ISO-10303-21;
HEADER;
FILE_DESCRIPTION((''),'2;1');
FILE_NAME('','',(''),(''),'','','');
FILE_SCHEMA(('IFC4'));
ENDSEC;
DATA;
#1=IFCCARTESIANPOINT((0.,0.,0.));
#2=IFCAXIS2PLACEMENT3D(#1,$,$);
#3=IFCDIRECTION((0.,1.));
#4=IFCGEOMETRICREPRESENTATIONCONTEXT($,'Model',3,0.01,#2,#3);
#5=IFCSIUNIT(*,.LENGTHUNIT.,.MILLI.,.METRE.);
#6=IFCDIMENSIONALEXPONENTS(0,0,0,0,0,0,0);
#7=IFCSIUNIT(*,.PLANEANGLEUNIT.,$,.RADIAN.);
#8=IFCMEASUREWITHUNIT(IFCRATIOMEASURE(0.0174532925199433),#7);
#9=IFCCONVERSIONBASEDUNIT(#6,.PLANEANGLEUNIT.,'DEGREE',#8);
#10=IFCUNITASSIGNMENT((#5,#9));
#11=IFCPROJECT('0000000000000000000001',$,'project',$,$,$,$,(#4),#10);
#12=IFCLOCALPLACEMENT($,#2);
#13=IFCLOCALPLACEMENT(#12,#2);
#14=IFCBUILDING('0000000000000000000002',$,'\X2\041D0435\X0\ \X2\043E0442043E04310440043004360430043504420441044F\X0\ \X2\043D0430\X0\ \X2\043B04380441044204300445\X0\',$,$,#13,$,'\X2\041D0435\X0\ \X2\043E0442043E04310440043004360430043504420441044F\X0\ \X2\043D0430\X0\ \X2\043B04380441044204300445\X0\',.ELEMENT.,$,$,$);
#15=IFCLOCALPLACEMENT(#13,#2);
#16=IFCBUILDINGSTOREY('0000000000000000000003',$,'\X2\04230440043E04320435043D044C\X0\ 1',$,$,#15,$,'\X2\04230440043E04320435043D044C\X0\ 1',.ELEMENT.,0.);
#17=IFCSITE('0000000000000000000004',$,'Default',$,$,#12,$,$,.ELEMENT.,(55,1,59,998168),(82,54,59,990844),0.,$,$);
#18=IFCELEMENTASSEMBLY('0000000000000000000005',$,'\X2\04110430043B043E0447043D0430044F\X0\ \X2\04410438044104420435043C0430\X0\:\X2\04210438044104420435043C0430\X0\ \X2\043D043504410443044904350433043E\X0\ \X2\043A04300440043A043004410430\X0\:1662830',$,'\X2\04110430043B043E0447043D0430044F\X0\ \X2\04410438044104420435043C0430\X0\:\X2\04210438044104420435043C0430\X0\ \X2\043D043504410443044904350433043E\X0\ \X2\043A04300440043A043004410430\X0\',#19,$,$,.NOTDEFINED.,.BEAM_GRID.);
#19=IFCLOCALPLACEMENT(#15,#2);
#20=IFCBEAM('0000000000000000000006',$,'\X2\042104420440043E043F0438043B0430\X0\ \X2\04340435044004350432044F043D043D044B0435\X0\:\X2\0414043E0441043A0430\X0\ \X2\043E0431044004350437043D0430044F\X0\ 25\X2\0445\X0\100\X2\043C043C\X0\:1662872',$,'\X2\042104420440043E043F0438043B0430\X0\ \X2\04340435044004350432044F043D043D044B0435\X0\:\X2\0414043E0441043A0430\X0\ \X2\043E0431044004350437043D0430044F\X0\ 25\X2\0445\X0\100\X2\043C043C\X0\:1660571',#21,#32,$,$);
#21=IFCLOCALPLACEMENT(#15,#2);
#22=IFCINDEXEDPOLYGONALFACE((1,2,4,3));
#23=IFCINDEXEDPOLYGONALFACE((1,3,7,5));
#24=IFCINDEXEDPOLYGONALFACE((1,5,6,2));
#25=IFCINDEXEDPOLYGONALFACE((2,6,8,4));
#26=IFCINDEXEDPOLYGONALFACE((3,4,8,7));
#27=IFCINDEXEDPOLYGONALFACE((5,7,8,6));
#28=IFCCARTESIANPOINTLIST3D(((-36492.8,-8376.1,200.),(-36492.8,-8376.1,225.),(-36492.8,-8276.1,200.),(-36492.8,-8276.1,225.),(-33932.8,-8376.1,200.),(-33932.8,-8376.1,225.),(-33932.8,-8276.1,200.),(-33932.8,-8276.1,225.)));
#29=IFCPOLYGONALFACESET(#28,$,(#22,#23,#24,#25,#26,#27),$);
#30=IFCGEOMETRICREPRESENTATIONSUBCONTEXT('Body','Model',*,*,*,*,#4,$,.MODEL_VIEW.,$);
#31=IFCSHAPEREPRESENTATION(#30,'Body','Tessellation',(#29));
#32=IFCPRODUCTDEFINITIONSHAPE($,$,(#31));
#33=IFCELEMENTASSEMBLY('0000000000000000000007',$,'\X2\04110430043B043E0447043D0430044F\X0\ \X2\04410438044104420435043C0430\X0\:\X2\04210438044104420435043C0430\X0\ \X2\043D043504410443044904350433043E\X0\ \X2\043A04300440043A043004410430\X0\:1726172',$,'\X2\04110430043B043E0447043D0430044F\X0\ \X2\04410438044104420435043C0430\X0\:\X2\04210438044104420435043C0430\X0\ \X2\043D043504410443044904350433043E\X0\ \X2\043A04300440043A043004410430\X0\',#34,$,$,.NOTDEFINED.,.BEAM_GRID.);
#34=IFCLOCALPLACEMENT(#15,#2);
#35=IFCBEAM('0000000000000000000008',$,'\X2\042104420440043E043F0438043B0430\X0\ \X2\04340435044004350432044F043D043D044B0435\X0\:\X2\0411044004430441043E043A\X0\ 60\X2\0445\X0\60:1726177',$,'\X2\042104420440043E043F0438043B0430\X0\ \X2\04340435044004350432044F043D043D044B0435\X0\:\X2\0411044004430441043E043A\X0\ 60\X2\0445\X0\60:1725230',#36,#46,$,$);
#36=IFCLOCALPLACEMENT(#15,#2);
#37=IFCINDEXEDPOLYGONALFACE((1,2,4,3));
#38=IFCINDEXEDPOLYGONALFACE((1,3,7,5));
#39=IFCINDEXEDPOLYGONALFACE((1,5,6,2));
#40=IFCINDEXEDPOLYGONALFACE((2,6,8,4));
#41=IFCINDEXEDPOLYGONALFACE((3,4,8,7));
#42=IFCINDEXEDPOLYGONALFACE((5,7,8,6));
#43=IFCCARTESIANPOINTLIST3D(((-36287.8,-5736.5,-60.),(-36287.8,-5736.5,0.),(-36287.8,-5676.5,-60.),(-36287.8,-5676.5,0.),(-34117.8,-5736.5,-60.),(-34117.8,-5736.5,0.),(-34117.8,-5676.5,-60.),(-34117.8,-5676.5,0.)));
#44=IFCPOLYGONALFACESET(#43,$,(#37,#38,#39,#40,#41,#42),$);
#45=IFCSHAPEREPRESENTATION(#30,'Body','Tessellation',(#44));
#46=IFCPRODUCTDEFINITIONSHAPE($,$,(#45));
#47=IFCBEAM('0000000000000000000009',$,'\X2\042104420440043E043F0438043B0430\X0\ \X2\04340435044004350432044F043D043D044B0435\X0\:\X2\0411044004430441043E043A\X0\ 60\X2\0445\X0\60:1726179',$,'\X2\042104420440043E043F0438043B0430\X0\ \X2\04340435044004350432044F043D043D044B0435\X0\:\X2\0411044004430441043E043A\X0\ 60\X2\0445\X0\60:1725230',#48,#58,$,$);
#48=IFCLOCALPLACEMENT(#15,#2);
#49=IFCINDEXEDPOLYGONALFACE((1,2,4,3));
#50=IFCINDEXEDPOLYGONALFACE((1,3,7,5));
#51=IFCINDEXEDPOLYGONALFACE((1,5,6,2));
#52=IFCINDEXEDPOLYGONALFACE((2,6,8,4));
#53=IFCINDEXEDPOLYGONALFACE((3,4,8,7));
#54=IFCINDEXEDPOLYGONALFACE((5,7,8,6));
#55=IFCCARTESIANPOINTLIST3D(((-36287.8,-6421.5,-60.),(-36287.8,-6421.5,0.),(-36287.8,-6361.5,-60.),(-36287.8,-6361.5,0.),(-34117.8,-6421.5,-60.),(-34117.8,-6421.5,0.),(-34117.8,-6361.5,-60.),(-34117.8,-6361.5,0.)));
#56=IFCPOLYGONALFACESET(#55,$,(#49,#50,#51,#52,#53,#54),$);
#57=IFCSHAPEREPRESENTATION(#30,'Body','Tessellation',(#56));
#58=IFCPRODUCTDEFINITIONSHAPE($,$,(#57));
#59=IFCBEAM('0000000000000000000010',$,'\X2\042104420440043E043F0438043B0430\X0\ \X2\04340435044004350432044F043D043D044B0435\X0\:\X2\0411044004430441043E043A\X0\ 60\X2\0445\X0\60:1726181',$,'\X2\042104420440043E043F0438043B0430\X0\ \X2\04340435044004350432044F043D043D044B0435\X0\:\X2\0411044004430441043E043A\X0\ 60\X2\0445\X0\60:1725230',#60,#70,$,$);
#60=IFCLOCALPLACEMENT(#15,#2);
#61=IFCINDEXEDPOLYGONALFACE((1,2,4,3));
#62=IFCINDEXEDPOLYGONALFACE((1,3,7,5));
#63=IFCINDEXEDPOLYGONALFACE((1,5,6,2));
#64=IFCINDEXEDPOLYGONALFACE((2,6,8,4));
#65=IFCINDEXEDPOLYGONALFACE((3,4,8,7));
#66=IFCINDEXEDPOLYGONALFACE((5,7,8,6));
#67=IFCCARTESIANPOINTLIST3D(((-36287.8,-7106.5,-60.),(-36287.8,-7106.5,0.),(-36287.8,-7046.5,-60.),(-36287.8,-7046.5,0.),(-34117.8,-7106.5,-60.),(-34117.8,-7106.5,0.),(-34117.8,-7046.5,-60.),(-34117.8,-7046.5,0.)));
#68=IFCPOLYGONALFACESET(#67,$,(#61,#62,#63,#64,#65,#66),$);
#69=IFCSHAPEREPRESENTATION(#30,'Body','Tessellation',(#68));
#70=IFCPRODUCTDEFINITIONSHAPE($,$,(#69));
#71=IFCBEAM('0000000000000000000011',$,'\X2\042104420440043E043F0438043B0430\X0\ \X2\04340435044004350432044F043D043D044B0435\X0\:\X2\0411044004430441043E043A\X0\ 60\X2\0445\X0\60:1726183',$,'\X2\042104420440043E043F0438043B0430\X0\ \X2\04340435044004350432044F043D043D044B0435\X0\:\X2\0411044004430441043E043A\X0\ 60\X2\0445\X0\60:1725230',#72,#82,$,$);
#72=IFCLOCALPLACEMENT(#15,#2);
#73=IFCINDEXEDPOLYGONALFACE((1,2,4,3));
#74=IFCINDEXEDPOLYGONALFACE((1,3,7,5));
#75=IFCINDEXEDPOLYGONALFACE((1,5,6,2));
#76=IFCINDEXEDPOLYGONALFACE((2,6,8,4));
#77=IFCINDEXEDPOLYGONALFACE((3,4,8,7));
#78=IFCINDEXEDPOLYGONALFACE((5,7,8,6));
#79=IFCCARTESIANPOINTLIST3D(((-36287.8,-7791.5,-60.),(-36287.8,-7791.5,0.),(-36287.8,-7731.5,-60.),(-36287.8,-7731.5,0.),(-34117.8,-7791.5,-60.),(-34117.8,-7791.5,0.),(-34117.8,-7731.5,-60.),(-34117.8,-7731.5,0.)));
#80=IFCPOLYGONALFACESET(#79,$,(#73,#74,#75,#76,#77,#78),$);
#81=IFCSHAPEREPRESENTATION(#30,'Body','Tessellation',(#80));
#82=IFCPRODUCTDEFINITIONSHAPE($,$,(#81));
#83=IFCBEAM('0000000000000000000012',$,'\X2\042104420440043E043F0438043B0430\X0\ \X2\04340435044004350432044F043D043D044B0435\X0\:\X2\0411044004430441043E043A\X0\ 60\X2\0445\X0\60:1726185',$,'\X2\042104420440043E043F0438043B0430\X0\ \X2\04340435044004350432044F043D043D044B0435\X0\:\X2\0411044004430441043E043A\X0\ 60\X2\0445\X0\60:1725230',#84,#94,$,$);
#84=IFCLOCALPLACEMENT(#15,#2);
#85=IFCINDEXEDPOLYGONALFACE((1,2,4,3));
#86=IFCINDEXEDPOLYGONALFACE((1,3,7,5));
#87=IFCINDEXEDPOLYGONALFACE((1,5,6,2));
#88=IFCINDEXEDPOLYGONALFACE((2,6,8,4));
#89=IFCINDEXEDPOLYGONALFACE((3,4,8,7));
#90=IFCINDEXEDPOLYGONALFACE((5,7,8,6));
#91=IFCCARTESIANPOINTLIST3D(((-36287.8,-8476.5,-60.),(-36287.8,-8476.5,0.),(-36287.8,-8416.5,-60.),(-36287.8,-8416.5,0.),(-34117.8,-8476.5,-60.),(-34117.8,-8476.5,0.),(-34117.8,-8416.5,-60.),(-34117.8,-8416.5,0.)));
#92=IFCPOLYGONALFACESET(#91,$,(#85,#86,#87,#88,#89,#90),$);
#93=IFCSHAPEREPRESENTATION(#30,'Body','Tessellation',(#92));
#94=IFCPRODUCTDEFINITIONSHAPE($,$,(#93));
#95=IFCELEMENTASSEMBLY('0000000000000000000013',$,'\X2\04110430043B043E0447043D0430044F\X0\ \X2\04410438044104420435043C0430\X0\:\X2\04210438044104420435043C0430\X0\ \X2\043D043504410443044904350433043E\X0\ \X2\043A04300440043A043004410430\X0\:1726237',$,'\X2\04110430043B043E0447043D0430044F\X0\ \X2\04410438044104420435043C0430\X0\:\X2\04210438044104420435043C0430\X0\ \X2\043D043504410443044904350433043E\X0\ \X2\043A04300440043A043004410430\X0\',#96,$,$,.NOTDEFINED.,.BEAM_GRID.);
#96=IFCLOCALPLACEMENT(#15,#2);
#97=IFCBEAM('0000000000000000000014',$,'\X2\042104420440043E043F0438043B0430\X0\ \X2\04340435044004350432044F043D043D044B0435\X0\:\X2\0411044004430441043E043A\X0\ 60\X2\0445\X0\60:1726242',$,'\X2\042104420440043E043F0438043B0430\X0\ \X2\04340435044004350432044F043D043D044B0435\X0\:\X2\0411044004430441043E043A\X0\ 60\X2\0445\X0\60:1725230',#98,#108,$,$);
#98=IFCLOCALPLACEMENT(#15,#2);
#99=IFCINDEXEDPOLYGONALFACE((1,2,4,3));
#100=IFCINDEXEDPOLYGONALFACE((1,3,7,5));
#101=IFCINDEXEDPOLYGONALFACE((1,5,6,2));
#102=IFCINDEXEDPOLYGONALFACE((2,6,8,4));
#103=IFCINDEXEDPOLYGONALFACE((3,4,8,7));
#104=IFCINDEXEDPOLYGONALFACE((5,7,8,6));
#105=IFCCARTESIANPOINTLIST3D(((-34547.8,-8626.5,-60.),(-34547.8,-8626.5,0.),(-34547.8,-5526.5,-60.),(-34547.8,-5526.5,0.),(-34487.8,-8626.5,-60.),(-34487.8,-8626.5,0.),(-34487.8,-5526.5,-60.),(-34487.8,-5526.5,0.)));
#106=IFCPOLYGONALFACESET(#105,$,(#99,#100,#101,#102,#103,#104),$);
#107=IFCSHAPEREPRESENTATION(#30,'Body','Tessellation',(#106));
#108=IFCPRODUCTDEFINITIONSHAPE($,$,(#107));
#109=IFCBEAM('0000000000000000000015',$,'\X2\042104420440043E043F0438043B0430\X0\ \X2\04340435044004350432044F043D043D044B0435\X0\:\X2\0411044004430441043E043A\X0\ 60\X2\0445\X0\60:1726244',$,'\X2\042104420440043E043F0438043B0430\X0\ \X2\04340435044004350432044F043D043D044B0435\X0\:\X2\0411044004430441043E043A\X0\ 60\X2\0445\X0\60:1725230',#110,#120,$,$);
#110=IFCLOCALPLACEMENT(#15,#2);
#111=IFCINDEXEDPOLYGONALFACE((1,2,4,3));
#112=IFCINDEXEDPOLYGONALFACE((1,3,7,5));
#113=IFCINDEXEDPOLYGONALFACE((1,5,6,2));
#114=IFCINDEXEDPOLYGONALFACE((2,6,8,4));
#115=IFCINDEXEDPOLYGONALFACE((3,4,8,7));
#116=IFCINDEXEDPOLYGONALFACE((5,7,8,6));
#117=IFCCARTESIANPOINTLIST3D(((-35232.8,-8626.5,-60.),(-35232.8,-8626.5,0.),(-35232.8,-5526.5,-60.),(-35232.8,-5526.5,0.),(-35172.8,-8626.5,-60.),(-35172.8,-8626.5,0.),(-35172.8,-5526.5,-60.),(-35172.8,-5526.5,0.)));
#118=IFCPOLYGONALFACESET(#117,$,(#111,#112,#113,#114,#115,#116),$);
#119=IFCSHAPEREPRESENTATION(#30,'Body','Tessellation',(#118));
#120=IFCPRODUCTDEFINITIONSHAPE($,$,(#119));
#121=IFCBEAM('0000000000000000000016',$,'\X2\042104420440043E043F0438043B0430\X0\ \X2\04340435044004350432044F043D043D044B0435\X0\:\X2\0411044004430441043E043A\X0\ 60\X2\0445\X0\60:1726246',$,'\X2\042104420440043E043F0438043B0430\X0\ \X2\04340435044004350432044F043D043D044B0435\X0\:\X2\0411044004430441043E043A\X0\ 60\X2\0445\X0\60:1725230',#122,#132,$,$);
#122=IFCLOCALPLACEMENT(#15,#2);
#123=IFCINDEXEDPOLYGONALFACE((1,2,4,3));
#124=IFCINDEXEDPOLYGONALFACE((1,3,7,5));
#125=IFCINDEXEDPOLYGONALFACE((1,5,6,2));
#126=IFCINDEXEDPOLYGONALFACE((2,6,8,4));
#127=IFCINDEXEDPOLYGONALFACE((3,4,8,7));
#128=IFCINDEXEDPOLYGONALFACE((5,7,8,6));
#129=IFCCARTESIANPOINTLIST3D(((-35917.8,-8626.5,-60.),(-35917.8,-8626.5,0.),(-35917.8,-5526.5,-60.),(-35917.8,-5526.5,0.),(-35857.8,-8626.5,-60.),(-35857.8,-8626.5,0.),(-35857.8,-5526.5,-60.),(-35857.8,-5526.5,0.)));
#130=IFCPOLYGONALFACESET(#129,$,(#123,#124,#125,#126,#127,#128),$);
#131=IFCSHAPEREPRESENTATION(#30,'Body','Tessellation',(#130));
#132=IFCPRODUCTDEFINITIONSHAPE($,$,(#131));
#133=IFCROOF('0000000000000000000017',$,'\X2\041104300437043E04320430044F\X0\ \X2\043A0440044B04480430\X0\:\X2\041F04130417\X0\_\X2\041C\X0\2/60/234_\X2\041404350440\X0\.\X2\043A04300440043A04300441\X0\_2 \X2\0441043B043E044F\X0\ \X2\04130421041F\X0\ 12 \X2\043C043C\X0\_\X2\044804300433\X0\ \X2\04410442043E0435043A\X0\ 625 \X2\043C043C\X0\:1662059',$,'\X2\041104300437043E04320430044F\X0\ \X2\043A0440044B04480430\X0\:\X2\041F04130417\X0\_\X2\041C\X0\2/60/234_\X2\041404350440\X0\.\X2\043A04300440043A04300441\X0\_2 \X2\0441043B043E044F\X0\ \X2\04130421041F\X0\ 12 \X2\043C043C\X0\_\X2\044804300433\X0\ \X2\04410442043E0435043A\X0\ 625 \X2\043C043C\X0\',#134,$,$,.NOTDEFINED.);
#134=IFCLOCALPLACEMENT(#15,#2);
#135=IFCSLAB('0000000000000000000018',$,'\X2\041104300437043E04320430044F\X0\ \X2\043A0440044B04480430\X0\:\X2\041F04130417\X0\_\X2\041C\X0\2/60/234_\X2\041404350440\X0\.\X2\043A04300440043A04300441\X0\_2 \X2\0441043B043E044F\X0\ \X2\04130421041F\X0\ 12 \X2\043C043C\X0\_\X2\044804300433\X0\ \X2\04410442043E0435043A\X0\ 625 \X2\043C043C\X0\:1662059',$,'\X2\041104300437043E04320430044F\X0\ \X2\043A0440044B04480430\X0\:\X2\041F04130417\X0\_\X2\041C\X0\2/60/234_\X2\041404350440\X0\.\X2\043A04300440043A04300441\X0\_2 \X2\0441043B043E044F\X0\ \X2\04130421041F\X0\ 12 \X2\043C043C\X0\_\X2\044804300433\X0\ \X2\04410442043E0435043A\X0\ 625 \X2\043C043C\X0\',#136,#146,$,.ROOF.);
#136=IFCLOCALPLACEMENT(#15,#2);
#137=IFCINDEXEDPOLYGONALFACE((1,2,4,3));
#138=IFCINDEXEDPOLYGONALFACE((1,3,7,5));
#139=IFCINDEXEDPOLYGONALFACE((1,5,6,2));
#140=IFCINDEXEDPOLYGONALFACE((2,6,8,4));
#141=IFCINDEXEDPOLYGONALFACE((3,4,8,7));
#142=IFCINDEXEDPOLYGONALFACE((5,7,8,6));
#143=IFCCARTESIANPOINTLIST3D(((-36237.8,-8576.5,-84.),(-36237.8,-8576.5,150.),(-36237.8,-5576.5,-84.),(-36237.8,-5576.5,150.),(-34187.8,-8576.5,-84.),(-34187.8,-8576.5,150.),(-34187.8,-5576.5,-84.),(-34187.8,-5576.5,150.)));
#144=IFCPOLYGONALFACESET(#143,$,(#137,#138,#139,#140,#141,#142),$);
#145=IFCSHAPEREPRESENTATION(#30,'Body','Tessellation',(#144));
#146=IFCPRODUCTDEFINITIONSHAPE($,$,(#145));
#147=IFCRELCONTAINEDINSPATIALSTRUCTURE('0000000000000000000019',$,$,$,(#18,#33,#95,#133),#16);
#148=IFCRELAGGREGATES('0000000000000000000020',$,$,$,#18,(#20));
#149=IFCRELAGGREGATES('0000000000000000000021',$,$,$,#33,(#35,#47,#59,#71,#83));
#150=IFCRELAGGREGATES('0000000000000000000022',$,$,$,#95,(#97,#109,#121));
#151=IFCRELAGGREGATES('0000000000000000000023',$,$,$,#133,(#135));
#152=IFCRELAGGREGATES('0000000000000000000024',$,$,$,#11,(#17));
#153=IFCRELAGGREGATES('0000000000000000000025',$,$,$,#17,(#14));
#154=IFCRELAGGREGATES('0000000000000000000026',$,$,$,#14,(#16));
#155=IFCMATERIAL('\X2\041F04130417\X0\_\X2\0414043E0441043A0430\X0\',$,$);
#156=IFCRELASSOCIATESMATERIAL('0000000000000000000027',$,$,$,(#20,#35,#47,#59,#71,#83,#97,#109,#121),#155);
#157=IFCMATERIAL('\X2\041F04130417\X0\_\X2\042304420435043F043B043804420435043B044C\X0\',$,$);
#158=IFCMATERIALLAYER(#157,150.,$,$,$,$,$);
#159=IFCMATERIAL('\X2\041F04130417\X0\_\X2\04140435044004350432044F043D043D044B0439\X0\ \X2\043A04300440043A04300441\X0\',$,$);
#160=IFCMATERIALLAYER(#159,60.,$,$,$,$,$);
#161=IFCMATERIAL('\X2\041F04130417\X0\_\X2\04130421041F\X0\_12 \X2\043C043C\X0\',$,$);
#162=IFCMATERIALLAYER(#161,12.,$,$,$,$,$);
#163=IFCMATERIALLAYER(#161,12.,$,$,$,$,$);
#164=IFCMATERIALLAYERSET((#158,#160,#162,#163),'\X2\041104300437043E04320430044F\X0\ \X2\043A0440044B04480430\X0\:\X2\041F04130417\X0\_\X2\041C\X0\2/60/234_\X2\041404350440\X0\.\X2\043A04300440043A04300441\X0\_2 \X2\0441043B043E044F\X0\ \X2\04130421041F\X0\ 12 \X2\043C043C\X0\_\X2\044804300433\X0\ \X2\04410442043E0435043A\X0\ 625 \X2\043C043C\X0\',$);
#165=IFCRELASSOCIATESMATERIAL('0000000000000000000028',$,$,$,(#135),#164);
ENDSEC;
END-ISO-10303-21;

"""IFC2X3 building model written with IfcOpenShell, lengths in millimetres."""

from ifc_helpers import new_model, entity, si_unit, converted_unit, direction, frame, frame_2d, origin, place, context, subcontext, project, spatial, rectangle, extrude, material, layer, layer_set, element, aggregate, save


model = new_model("IFC2X3")

# Units and contexts
model_context = context("Model", 3, precision=0.01, world=origin(), true_north=direction((0.0, 1.0)))
body_context = subcontext(model_context, "Body", "Model", "MODEL_VIEW")
ifc_project = project(units=[si_unit("LENGTHUNIT", "METRE", prefix="MILLI"), converted_unit("PLANEANGLEUNIT", "DEGREE", entity("IfcRatioMeasure", 0.0174532925199433), si_unit("PLANEANGLEUNIT", "RADIAN"), dimensions=[0, 0, 0, 0, 0, 0, 0])], contexts=[model_context])

# Site, building, storey
site_placement = place(None, origin())
site = spatial("IfcSite", under=ifc_project, at=site_placement, Name="Default", CompositionType="ELEMENT", RefLatitude=(55, 1, 59, 998168), RefLongitude=(82, 54, 59, 990844), RefElevation=0.0)
building_placement = place(site_placement, origin())
building = spatial("IfcBuilding", under=site, at=building_placement, Name="Не отображается на листах", LongName="Не отображается на листах", CompositionType="ELEMENT")
storey_placement = place(building_placement, frame((0.0, 0.0, 0.0)))
storey = spatial("IfcBuildingStorey", under=building, at=storey_placement, Name="Уровень 1", LongName="Уровень 1", CompositionType="ELEMENT", Elevation=0.0)

# Element assemblies, beams
ifc_material_1 = material(Name="ПГЗ_Доска")
assembly_1_placement = place(storey_placement, origin())
assembly_1 = element("IfcElementAssembly", 1, at=assembly_1_placement, inside=storey, Name="Балочная система:Система несущего каркаса:1662830", ObjectType="Балочная система:Система несущего каркаса", AssemblyPlace="NOTDEFINED", PredefinedType="BEAM_GRID")
beam_1_placement = place(assembly_1_placement, frame((-36492.8, -8326.1, 0.0)))
beam_1 = element("IfcBeam", 2, at=beam_1_placement, material=ifc_material_1, Name="Стропила деревянные:Доска обрезная 25х100мм:1662872", ObjectType="Стропила деревянные:Доска обрезная 25х100мм:1660571", context=body_context, shape_type="SweptSolid", body=[
    extrude(rectangle(XDim=25.0, YDim=100.0, at=frame_2d((0.0, 0.0), x_axis=(1.0, 0.0))), frame((0.0, 0.0, 212.5), z_axis=(1.0, 0.0, 0.0), x_axis=(0.0, 0.0, -1.0)), (0.0, 0.0, 1.0), 2560.0),
])
aggregate(assembly_1, [beam_1])
assembly_2_placement = place(storey_placement, origin())
assembly_2 = element("IfcElementAssembly", 3, at=assembly_2_placement, inside=storey, Name="Балочная система:Система несущего каркаса:1726172", ObjectType="Балочная система:Система несущего каркаса", AssemblyPlace="NOTDEFINED", PredefinedType="BEAM_GRID")
beam_2_placement = place(assembly_2_placement, frame((-36287.8, -5706.5, 0.0)))
beam_2 = element("IfcBeam", 4, at=beam_2_placement, material=ifc_material_1, Name="Стропила деревянные:Брусок 60х60:1726177", ObjectType="Стропила деревянные:Брусок 60х60:1725230", context=body_context, shape_type="SweptSolid", body=[
    extrude(rectangle(XDim=60.0, YDim=60.0, at=frame_2d((0.0, 0.0), x_axis=(1.0, 0.0))), frame((0.0, 0.0, -30.0), z_axis=(1.0, 0.0, 0.0), x_axis=(0.0, 0.0, -1.0)), (0.0, 0.0, 1.0), 2170.0),
])
beam_3_placement = place(assembly_2_placement, frame((-36287.8, -6391.5, 0.0)))
beam_3 = element("IfcBeam", 5, at=beam_3_placement, material=ifc_material_1, Name="Стропила деревянные:Брусок 60х60:1726179", ObjectType="Стропила деревянные:Брусок 60х60:1725230", context=body_context, shape_type="SweptSolid", body=[
    extrude(rectangle(XDim=60.0, YDim=60.0, at=frame_2d((0.0, 0.0), x_axis=(1.0, 0.0))), frame((0.0, 0.0, -30.0), z_axis=(1.0, 0.0, 0.0), x_axis=(0.0, 0.0, -1.0)), (0.0, 0.0, 1.0), 2170.0),
])
beam_4_placement = place(assembly_2_placement, frame((-36287.8, -7076.5, 0.0)))
beam_4 = element("IfcBeam", 6, at=beam_4_placement, material=ifc_material_1, Name="Стропила деревянные:Брусок 60х60:1726181", ObjectType="Стропила деревянные:Брусок 60х60:1725230", context=body_context, shape_type="SweptSolid", body=[
    extrude(rectangle(XDim=60.0, YDim=60.0, at=frame_2d((0.0, 0.0), x_axis=(1.0, 0.0))), frame((0.0, 0.0, -30.0), z_axis=(1.0, 0.0, 0.0), x_axis=(0.0, 0.0, -1.0)), (0.0, 0.0, 1.0), 2170.0),
])
beam_5_placement = place(assembly_2_placement, frame((-36287.8, -7761.5, 0.0)))
beam_5 = element("IfcBeam", 7, at=beam_5_placement, material=ifc_material_1, Name="Стропила деревянные:Брусок 60х60:1726183", ObjectType="Стропила деревянные:Брусок 60х60:1725230", context=body_context, shape_type="SweptSolid", body=[
    extrude(rectangle(XDim=60.0, YDim=60.0, at=frame_2d((0.0, 0.0), x_axis=(1.0, 0.0))), frame((0.0, 0.0, -30.0), z_axis=(1.0, 0.0, 0.0), x_axis=(0.0, 0.0, -1.0)), (0.0, 0.0, 1.0), 2170.0),
])
beam_6_placement = place(assembly_2_placement, frame((-36287.8, -8446.5, 0.0)))
beam_6 = element("IfcBeam", 8, at=beam_6_placement, material=ifc_material_1, Name="Стропила деревянные:Брусок 60х60:1726185", ObjectType="Стропила деревянные:Брусок 60х60:1725230", context=body_context, shape_type="SweptSolid", body=[
    extrude(rectangle(XDim=60.0, YDim=60.0, at=frame_2d((0.0, 0.0), x_axis=(1.0, 0.0))), frame((0.0, 0.0, -30.0), z_axis=(1.0, 0.0, 0.0), x_axis=(0.0, 0.0, -1.0)), (0.0, 0.0, 1.0), 2170.0),
])
aggregate(assembly_2, [beam_2, beam_3, beam_4, beam_5, beam_6])
assembly_3_placement = place(storey_placement, origin())
assembly_3 = element("IfcElementAssembly", 9, at=assembly_3_placement, inside=storey, Name="Балочная система:Система несущего каркаса:1726237", ObjectType="Балочная система:Система несущего каркаса", AssemblyPlace="NOTDEFINED", PredefinedType="BEAM_GRID")
beam_7_placement = place(assembly_3_placement, frame((-34517.8, -5526.5, 0.0), z_axis=(0.0, 0.0, 1.0), x_axis=(0.0, -1.0, 0.0)))
beam_7 = element("IfcBeam", 10, at=beam_7_placement, material=ifc_material_1, Name="Стропила деревянные:Брусок 60х60:1726242", ObjectType="Стропила деревянные:Брусок 60х60:1725230", context=body_context, shape_type="SweptSolid", body=[
    extrude(rectangle(XDim=60.0, YDim=60.0, at=frame_2d((0.0, 0.0), x_axis=(1.0, 0.0))), frame((0.0, 0.0, -30.0), z_axis=(1.0, 0.0, 0.0), x_axis=(0.0, 0.0, -1.0)), (0.0, 0.0, 1.0), 3100.0),
])
beam_8_placement = place(assembly_3_placement, frame((-35202.8, -5526.5, 0.0), z_axis=(0.0, 0.0, 1.0), x_axis=(0.0, -1.0, 0.0)))
beam_8 = element("IfcBeam", 11, at=beam_8_placement, material=ifc_material_1, Name="Стропила деревянные:Брусок 60х60:1726244", ObjectType="Стропила деревянные:Брусок 60х60:1725230", context=body_context, shape_type="SweptSolid", body=[
    extrude(rectangle(XDim=60.0, YDim=60.0, at=frame_2d((0.0, 0.0), x_axis=(1.0, 0.0))), frame((0.0, 0.0, -30.0), z_axis=(1.0, 0.0, 0.0), x_axis=(0.0, 0.0, -1.0)), (0.0, 0.0, 1.0), 3100.0),
])
beam_9_placement = place(assembly_3_placement, frame((-35887.8, -5526.5, 0.0), z_axis=(0.0, 0.0, 1.0), x_axis=(0.0, -1.0, 0.0)))
beam_9 = element("IfcBeam", 12, at=beam_9_placement, material=ifc_material_1, Name="Стропила деревянные:Брусок 60х60:1726246", ObjectType="Стропила деревянные:Брусок 60х60:1725230", context=body_context, shape_type="SweptSolid", body=[
    extrude(rectangle(XDim=60.0, YDim=60.0, at=frame_2d((0.0, 0.0), x_axis=(1.0, 0.0))), frame((0.0, 0.0, -30.0), z_axis=(1.0, 0.0, 0.0), x_axis=(0.0, 0.0, -1.0)), (0.0, 0.0, 1.0), 3100.0),
])
aggregate(assembly_3, [beam_7, beam_8, beam_9])

# Roof, slab
roof_placement = place(storey_placement, frame((-36237.8, -8576.5, -84.0)))
roof = element("IfcRoof", 13, at=roof_placement, inside=storey, Name="Базовая крыша:ПГЗ_М2/60/234_Дер.каркас_2 слоя ГСП 12 мм_шаг стоек 625 мм:1662059", ObjectType="Базовая крыша:ПГЗ_М2/60/234_Дер.каркас_2 слоя ГСП 12 мм_шаг стоек 625 мм", ShapeType="NOTDEFINED")
ifc_material_2 = material(Name="ПГЗ_Утеплитель")
ifc_layer_1 = layer(ifc_material_2, 150.0)
ifc_material_3 = material(Name="ПГЗ_Деревянный каркас")
ifc_layer_2 = layer(ifc_material_3, 60.0)
ifc_material_4 = material(Name="ПГЗ_ГСП_12 мм")
ifc_layer_3 = layer(ifc_material_4, 12.0)
ifc_layer_4 = layer(ifc_material_4, 12.0)
ifc_layer_set = layer_set([ifc_layer_1, ifc_layer_2, ifc_layer_3, ifc_layer_4], Name="Базовая крыша:ПГЗ_М2/60/234_Дер.каркас_2 слоя ГСП 12 мм_шаг стоек 625 мм")
slab_placement = place(roof_placement, origin())
slab = element("IfcSlab", 14, at=slab_placement, material=ifc_layer_set, Name="Базовая крыша:ПГЗ_М2/60/234_Дер.каркас_2 слоя ГСП 12 мм_шаг стоек 625 мм:1662059", ObjectType="Базовая крыша:ПГЗ_М2/60/234_Дер.каркас_2 слоя ГСП 12 мм_шаг стоек 625 мм", PredefinedType="ROOF", context=body_context, shape_type="SweptSolid", body=[
    extrude(rectangle(XDim=2050.0, YDim=3000.0, at=frame_2d((0.0, 0.0), x_axis=(1.0, 0.0))), frame((1025.0, 1500.0, 0.0)), (0.0, 0.0, 1.0), 234.0),
])
aggregate(roof, [slab])

save(model, "model.ifc")
